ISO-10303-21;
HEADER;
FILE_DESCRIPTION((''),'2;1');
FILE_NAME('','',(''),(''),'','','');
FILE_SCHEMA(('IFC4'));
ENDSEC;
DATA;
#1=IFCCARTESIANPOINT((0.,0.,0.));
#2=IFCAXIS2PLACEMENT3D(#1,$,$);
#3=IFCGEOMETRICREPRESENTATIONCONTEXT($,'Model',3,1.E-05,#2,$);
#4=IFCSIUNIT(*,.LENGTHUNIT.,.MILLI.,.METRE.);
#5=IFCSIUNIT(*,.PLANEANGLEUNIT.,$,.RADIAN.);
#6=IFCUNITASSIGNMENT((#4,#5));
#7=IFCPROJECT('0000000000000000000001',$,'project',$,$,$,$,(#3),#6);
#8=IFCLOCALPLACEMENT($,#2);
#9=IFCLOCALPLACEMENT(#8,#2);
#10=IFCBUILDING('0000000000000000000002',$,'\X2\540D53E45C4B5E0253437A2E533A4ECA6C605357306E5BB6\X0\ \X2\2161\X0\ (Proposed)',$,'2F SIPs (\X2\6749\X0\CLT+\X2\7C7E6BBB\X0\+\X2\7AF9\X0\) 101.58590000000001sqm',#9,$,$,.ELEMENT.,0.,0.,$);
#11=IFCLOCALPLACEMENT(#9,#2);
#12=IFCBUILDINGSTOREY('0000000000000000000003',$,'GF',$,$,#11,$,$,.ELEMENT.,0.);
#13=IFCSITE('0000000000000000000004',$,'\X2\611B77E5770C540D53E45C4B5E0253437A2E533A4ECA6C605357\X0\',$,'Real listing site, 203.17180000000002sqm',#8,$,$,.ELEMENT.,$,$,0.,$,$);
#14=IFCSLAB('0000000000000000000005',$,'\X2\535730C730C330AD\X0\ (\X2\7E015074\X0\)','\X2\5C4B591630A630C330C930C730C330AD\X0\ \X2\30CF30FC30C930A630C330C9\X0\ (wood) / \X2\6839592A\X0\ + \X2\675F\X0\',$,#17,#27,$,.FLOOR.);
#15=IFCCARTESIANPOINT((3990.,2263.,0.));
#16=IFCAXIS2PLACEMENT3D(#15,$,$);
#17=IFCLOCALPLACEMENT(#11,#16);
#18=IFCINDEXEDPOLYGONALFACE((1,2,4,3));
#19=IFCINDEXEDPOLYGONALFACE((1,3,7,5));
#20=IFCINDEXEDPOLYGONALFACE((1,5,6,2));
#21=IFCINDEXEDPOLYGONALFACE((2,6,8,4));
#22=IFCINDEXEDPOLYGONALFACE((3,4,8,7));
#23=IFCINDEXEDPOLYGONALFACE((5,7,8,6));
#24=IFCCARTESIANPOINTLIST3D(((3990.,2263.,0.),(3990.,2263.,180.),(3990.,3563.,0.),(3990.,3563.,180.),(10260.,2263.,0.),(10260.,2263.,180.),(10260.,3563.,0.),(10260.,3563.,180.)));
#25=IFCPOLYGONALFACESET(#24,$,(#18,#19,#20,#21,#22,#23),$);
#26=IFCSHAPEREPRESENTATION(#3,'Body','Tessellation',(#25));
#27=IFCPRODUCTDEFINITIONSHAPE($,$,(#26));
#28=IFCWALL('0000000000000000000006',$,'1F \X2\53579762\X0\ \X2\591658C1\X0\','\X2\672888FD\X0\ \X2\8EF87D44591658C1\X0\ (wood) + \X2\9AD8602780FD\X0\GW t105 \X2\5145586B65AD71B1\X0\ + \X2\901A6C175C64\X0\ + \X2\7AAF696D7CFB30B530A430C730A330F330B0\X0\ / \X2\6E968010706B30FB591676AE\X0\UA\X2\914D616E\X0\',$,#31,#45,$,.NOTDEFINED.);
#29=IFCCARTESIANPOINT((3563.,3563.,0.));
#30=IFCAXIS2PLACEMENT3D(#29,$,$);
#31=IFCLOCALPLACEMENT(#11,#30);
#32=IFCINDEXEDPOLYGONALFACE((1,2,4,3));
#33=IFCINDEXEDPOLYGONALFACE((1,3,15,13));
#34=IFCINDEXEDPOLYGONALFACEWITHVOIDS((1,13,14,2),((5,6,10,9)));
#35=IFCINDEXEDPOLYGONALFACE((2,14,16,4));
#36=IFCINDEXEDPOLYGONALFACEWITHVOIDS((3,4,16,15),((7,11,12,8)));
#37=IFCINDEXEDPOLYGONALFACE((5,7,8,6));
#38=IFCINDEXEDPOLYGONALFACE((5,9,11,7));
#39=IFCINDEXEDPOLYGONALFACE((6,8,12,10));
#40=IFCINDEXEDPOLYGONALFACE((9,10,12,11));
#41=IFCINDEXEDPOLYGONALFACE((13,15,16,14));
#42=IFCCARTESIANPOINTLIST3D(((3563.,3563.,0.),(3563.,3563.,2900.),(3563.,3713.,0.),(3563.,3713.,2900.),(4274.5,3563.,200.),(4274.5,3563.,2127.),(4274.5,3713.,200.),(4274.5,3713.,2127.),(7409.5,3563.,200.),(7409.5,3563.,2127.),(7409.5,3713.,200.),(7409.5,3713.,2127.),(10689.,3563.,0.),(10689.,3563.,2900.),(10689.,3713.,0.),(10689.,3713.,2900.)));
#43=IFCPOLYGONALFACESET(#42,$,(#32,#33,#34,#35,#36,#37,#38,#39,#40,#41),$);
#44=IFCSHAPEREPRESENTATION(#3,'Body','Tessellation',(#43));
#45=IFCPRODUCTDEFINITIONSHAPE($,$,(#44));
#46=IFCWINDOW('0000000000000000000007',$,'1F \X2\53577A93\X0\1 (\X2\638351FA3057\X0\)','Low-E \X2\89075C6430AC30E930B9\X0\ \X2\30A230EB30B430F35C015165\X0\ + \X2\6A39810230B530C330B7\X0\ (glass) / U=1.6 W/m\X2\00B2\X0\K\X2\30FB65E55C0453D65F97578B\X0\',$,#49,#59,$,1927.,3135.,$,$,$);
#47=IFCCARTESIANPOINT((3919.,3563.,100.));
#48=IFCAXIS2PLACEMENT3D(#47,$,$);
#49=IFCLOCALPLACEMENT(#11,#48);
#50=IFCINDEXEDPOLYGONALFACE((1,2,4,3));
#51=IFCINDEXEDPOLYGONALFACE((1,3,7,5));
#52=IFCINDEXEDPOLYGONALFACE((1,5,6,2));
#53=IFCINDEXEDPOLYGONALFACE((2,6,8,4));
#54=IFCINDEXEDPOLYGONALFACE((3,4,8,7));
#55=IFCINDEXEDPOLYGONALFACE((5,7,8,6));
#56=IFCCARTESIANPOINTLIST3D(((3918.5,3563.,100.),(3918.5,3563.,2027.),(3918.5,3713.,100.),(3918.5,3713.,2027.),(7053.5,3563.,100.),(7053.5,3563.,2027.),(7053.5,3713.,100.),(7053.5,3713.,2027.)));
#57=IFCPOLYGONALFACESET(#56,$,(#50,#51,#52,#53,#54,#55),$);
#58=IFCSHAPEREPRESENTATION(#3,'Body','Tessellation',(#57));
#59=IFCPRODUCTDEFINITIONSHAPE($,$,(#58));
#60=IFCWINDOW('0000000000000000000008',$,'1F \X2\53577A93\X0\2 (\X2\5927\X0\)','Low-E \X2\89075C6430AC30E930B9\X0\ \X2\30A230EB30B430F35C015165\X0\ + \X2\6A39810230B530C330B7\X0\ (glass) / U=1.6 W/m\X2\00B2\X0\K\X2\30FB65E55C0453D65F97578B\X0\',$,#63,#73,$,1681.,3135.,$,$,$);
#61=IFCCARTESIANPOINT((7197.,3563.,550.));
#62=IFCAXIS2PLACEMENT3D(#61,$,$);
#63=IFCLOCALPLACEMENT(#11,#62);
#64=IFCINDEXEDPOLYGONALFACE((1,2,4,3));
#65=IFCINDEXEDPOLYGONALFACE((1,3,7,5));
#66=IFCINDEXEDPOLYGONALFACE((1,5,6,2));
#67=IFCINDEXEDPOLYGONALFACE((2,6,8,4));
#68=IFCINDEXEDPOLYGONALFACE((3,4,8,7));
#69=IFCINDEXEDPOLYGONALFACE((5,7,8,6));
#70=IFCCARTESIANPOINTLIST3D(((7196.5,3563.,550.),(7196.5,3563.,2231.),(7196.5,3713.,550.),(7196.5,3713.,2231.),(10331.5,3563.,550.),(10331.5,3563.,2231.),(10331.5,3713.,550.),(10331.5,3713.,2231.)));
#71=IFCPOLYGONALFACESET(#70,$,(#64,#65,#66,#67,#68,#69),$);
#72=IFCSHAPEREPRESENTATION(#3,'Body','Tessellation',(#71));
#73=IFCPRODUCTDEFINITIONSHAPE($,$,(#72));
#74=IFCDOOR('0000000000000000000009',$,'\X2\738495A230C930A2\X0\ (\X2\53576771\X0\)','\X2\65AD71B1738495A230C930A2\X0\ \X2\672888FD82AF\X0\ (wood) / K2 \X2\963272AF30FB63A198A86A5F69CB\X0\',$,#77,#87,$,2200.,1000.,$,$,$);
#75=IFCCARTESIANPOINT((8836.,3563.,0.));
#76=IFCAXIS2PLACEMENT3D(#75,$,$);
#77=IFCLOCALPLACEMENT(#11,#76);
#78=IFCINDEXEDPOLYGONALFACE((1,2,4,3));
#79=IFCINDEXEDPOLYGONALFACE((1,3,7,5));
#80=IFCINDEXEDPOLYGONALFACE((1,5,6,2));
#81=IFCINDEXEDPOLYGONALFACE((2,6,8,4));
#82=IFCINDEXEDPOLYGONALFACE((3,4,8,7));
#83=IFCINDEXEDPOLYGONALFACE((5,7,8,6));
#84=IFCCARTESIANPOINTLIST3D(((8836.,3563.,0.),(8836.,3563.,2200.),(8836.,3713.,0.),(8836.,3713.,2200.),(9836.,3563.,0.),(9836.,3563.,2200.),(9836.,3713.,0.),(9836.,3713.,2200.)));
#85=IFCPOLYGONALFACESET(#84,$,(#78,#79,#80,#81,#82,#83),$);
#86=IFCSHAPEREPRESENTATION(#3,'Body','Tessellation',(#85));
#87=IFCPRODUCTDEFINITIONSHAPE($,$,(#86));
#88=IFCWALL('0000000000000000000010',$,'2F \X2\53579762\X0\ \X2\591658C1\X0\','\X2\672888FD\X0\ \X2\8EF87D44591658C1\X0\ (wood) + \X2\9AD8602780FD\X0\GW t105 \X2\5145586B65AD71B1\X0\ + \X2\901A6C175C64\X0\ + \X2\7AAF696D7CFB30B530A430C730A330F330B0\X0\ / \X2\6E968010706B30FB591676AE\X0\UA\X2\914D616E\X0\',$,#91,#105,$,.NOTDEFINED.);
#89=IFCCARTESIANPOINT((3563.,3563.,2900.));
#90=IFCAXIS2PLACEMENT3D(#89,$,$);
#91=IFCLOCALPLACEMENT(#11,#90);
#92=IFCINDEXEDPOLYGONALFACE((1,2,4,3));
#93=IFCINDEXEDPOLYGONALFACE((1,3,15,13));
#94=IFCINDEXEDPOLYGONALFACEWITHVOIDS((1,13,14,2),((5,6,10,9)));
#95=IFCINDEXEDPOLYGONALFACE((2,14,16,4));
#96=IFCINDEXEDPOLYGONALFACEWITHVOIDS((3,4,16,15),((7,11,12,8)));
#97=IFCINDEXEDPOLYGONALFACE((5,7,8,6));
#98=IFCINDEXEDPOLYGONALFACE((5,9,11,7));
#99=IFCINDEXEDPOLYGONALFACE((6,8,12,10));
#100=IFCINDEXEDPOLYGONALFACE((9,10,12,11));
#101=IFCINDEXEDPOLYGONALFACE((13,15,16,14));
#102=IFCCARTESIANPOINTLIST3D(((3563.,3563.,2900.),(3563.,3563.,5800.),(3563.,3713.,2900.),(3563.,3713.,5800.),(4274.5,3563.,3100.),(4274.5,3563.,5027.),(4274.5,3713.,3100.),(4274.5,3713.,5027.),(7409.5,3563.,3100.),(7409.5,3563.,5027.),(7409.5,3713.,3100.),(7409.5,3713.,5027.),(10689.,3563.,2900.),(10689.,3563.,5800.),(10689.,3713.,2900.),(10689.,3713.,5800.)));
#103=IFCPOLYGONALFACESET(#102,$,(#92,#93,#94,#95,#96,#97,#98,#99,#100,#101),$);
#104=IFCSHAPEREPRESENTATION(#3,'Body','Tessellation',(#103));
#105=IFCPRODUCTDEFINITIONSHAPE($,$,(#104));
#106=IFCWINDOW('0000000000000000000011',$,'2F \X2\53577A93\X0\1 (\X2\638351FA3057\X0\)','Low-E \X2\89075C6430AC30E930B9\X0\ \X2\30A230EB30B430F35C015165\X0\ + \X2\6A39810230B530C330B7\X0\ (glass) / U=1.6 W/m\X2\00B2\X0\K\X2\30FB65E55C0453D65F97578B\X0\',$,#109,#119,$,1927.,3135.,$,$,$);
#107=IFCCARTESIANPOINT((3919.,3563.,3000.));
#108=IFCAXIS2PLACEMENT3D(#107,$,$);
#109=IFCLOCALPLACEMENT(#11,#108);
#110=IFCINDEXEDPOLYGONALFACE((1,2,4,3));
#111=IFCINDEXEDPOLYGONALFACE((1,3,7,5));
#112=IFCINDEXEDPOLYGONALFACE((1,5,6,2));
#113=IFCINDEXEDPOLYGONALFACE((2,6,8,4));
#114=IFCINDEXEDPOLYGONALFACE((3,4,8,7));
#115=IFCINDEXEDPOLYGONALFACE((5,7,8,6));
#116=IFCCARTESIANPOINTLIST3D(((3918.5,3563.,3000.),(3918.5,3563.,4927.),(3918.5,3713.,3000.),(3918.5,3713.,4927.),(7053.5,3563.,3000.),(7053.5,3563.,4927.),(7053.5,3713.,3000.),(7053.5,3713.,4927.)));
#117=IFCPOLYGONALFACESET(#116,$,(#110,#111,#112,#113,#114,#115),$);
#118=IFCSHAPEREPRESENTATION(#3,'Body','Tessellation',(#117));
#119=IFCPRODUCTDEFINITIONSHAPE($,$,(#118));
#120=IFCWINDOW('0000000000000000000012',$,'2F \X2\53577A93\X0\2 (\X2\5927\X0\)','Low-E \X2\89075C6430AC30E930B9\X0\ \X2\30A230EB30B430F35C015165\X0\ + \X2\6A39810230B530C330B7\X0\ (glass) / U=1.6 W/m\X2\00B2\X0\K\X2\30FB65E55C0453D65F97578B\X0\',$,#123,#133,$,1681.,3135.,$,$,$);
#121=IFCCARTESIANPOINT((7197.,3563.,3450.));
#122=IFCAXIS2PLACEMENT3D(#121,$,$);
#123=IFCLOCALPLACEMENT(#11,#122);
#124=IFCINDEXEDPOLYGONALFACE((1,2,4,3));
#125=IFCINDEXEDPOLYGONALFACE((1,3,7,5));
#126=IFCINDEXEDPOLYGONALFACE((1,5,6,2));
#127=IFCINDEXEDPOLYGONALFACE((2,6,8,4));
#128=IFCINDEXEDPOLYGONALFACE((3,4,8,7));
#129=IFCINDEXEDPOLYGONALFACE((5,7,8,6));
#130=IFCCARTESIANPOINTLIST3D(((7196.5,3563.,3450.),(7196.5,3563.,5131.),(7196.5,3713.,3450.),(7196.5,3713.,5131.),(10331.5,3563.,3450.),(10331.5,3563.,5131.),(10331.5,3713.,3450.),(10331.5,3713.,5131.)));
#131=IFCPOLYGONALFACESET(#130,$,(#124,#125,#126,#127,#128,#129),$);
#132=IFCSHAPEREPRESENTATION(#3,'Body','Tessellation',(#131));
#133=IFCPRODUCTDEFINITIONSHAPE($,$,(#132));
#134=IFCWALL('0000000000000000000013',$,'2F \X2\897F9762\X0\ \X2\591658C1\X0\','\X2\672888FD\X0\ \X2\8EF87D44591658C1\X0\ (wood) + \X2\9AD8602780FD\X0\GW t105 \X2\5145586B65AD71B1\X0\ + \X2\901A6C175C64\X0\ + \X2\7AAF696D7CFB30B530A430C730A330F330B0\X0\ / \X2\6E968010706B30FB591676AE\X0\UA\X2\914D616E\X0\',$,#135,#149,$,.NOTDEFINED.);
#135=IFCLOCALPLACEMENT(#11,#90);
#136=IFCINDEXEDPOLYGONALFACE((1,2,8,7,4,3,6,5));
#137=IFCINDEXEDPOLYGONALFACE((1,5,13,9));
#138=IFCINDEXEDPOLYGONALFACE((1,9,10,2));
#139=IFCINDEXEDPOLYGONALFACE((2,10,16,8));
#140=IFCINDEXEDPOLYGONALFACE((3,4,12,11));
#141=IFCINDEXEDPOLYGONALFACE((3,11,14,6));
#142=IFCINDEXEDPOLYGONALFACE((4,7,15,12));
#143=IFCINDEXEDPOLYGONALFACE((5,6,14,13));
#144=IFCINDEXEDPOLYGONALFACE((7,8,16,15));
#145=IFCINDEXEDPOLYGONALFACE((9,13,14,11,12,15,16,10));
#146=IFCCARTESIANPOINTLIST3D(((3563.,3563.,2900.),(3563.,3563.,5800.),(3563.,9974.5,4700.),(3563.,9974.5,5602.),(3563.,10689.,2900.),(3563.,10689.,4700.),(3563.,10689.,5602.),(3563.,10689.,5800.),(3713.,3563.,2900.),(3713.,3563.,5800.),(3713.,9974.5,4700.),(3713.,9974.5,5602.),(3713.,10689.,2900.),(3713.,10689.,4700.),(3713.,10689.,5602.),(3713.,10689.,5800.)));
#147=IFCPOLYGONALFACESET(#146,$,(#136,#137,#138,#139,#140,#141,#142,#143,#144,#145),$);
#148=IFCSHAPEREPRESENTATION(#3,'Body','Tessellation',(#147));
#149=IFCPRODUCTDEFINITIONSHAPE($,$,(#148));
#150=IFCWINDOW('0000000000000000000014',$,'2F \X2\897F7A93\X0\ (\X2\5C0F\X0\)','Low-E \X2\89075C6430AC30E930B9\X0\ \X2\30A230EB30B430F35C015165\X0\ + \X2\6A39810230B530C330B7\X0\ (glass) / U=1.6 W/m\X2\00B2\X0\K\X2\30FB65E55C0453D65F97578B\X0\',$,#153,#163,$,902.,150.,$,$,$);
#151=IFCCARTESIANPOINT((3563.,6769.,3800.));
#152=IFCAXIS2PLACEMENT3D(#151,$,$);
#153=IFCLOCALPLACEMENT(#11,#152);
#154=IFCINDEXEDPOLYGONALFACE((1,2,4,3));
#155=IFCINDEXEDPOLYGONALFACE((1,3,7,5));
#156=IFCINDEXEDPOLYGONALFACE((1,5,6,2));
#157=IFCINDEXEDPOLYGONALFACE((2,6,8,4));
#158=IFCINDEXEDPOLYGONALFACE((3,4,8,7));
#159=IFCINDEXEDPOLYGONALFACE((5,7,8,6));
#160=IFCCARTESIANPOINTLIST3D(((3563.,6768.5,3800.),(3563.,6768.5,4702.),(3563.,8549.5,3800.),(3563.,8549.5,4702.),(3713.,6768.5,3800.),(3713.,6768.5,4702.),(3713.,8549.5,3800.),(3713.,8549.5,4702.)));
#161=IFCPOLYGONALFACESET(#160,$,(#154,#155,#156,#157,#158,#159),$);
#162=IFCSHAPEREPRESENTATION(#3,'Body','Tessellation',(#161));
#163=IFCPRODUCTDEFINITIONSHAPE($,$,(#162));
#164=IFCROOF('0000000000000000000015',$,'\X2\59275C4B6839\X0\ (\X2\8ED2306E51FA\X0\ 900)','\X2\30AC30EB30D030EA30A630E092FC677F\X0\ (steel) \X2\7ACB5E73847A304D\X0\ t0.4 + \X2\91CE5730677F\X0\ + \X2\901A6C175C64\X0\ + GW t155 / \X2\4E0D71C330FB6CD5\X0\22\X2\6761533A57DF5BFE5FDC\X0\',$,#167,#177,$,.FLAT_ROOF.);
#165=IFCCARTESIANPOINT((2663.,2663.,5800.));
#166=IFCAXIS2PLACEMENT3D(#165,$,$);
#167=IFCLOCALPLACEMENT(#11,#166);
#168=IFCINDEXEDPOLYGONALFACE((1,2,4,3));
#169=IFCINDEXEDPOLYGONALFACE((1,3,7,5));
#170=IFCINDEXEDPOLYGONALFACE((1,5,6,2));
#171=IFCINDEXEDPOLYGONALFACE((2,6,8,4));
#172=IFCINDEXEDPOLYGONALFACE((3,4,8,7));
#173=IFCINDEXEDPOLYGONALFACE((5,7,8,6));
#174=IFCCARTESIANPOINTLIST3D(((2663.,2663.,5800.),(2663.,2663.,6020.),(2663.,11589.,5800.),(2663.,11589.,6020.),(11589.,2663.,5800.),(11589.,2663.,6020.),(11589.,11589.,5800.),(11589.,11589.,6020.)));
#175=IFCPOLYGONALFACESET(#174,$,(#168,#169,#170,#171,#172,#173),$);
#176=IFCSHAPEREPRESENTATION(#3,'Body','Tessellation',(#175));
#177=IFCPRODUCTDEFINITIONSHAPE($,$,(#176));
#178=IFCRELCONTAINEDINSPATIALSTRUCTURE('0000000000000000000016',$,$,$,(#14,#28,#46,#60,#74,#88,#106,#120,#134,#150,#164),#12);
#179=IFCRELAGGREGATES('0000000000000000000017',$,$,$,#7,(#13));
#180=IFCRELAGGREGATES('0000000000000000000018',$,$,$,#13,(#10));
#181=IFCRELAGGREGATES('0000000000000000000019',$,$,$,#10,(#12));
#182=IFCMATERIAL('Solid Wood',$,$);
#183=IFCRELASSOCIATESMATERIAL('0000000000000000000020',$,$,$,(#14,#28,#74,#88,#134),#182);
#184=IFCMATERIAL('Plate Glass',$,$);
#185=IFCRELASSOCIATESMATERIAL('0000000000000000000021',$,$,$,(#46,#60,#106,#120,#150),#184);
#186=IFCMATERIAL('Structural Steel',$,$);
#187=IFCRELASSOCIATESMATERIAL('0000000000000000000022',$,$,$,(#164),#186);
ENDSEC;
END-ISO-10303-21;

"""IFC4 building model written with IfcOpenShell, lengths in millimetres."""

from ifc_helpers import new_model, si_unit, frame, frame_2d, origin, place, context, project, spatial, rectangle, extrude, material, element, fill, save


model = new_model("IFC4")

# Units and contexts
model_context = context("Model", 3, precision=1e-05, world=origin())
ifc_project = project(units=[si_unit("LENGTHUNIT", "METRE", prefix="MILLI"), si_unit("PLANEANGLEUNIT", "RADIAN")], contexts=[model_context])

# Site, building, storey
site_placement = place(None, origin())
site = spatial("IfcSite", under=ifc_project, at=site_placement, Name="愛知県名古屋市千種区今池南", ObjectType="Real listing site, 203.17180000000002sqm", CompositionType="ELEMENT", RefElevation=0.0)
building_placement = place(site_placement, origin())
building = spatial("IfcBuilding", under=site, at=building_placement, Name="名古屋市千種区今池南の家 Ⅱ (Proposed)", ObjectType="2F SIPs (杉CLT+籾殻+竹) 101.58590000000001sqm", CompositionType="ELEMENT", ElevationOfRefHeight=0.0, ElevationOfTerrain=0.0)
storey_placement = place(building_placement, origin())
storey = spatial("IfcBuildingStorey", under=building, at=storey_placement, Name="GF", CompositionType="ELEMENT", Elevation=0.0)

# Slab
ifc_material_1 = material(Name="Solid Wood")
slab_1_placement = place(storey_placement, frame((3990.0, 2263.0, 0.0)))
element("IfcSlab", 1, at=slab_1_placement, inside=storey, material=ifc_material_1, Name="南デッキ (縁側)", Description="屋外ウッドデッキ ハードウッド (wood) / 根太 + 束", PredefinedType="FLOOR", context=model_context, shape_type="SweptSolid", body=[
    extrude(rectangle(XDim=6270.0, YDim=1300.0, at=frame_2d((3135.0, 650.0))), frame((3990.0, 2263.0, 0.0)), (0.0, 0.0, 1.0), 180.0),
])

# Wall, openings, windows, door
wall_1_placement = place(storey_placement, frame((3563.0, 3563.0, 0.0)))
wall_1 = element("IfcWall", 2, at=wall_1_placement, inside=storey, material=ifc_material_1, Name="1F 南面 外壁", Description="木製 軸組外壁 (wood) + 高性能GW t105 充填断熱 + 通気層 + 窯業系サイディング / 準耐火・外皮UA配慮", PredefinedType="NOTDEFINED", context=model_context, shape_type="SweptSolid", body=[
    extrude(rectangle(XDim=7126.0, YDim=150.0, at=frame_2d((3563.0, 75.0))), frame((3563.0, 3563.0, 0.0)), (0.0, 0.0, 1.0), 2900.0),
])
opening_1_placement = place(storey_placement, frame((3919.0, 3563.0, 100.0)))
opening_1 = element("IfcOpeningElement", 3, at=opening_1_placement, cuts=wall_1, PredefinedType="NOTDEFINED", context=model_context, shape_type="SweptSolid", body=[
    extrude(rectangle(XDim=3135.0, YDim=150.0, at=frame_2d((1567.0, 75.0))), frame((3919.0, 3563.0, 100.0)), (0.0, 0.0, 1.0), 1927.0),
])
opening_2_placement = place(storey_placement, frame((7197.0, 3563.0, 550.0)))
opening_2 = element("IfcOpeningElement", 4, at=opening_2_placement, cuts=wall_1, PredefinedType="NOTDEFINED", context=model_context, shape_type="SweptSolid", body=[
    extrude(rectangle(XDim=3135.0, YDim=150.0, at=frame_2d((1567.0, 75.0))), frame((7197.0, 3563.0, 550.0)), (0.0, 0.0, 1.0), 1681.0),
])
opening_3_placement = place(storey_placement, frame((8836.0, 3563.0, 0.0)))
opening_3 = element("IfcOpeningElement", 5, at=opening_3_placement, cuts=wall_1, PredefinedType="NOTDEFINED", context=model_context, shape_type="SweptSolid", body=[
    extrude(rectangle(XDim=1000.0, YDim=150.0, at=frame_2d((500.0, 75.0))), frame((8836.0, 3563.0, 0.0)), (0.0, 0.0, 1.0), 2200.0),
])
ifc_material_2 = material(Name="Plate Glass")
window_1_placement = place(storey_placement, frame((3919.0, 3563.0, 100.0)))
window_1 = element("IfcWindow", 6, at=window_1_placement, inside=storey, material=ifc_material_2, Name="1F 南窓1 (掃出し)", Description="Low-E 複層ガラス アルゴン封入 + 樹脂サッシ (glass) / U=1.6 W/m²K・日射取得型", OverallHeight=1927.0, OverallWidth=3135.0, context=model_context, shape_type="SweptSolid", body=[
    extrude(rectangle(XDim=3135.0, YDim=150.0, at=frame_2d((1567.0, 75.0))), frame((3919.0, 3563.0, 100.0)), (0.0, 0.0, 1.0), 1927.0),
])
fill(opening_1, window_1)
window_2_placement = place(storey_placement, frame((7197.0, 3563.0, 550.0)))
window_2 = element("IfcWindow", 7, at=window_2_placement, inside=storey, material=ifc_material_2, Name="1F 南窓2 (大)", Description="Low-E 複層ガラス アルゴン封入 + 樹脂サッシ (glass) / U=1.6 W/m²K・日射取得型", OverallHeight=1681.0, OverallWidth=3135.0, context=model_context, shape_type="SweptSolid", body=[
    extrude(rectangle(XDim=3135.0, YDim=150.0, at=frame_2d((1567.0, 75.0))), frame((7197.0, 3563.0, 550.0)), (0.0, 0.0, 1.0), 1681.0),
])
fill(opening_2, window_2)
door_placement = place(storey_placement, frame((8836.0, 3563.0, 0.0)))
door = element("IfcDoor", 8, at=door_placement, inside=storey, material=ifc_material_1, Name="玄関ドア (南東)", Description="断熱玄関ドア 木製芯 (wood) / K2 防犯・採風機構", OverallHeight=2200.0, OverallWidth=1000.0, context=model_context, shape_type="SweptSolid", body=[
    extrude(rectangle(XDim=1000.0, YDim=150.0, at=frame_2d((500.0, 75.0))), frame((8836.0, 3563.0, 0.0)), (0.0, 0.0, 1.0), 2200.0),
])
fill(opening_3, door)

# Wall, openings, windows
wall_2_placement = place(storey_placement, frame((3563.0, 3563.0, 2900.0)))
wall_2 = element("IfcWall", 9, at=wall_2_placement, inside=storey, material=ifc_material_1, Name="2F 南面 外壁", Description="木製 軸組外壁 (wood) + 高性能GW t105 充填断熱 + 通気層 + 窯業系サイディング / 準耐火・外皮UA配慮", PredefinedType="NOTDEFINED", context=model_context, shape_type="SweptSolid", body=[
    extrude(rectangle(XDim=7126.0, YDim=150.0, at=frame_2d((3563.0, 75.0))), frame((3563.0, 3563.0, 2900.0)), (0.0, 0.0, 1.0), 2900.0),
])
opening_4_placement = place(storey_placement, frame((3919.0, 3563.0, 3000.0)))
opening_4 = element("IfcOpeningElement", 10, at=opening_4_placement, cuts=wall_2, PredefinedType="NOTDEFINED", context=model_context, shape_type="SweptSolid", body=[
    extrude(rectangle(XDim=3135.0, YDim=150.0, at=frame_2d((1567.0, 75.0))), frame((3919.0, 3563.0, 3000.0)), (0.0, 0.0, 1.0), 1927.0),
])
opening_5_placement = place(storey_placement, frame((7197.0, 3563.0, 3450.0)))
opening_5 = element("IfcOpeningElement", 11, at=opening_5_placement, cuts=wall_2, PredefinedType="NOTDEFINED", context=model_context, shape_type="SweptSolid", body=[
    extrude(rectangle(XDim=3135.0, YDim=150.0, at=frame_2d((1567.0, 75.0))), frame((7197.0, 3563.0, 3450.0)), (0.0, 0.0, 1.0), 1681.0),
])
window_3_placement = place(storey_placement, frame((3919.0, 3563.0, 3000.0)))
window_3 = element("IfcWindow", 12, at=window_3_placement, inside=storey, material=ifc_material_2, Name="2F 南窓1 (掃出し)", Description="Low-E 複層ガラス アルゴン封入 + 樹脂サッシ (glass) / U=1.6 W/m²K・日射取得型", OverallHeight=1927.0, OverallWidth=3135.0, context=model_context, shape_type="SweptSolid", body=[
    extrude(rectangle(XDim=3135.0, YDim=150.0, at=frame_2d((1567.0, 75.0))), frame((3919.0, 3563.0, 3000.0)), (0.0, 0.0, 1.0), 1927.0),
])
fill(opening_4, window_3)
window_4_placement = place(storey_placement, frame((7197.0, 3563.0, 3450.0)))
window_4 = element("IfcWindow", 13, at=window_4_placement, inside=storey, material=ifc_material_2, Name="2F 南窓2 (大)", Description="Low-E 複層ガラス アルゴン封入 + 樹脂サッシ (glass) / U=1.6 W/m²K・日射取得型", OverallHeight=1681.0, OverallWidth=3135.0, context=model_context, shape_type="SweptSolid", body=[
    extrude(rectangle(XDim=3135.0, YDim=150.0, at=frame_2d((1567.0, 75.0))), frame((7197.0, 3563.0, 3450.0)), (0.0, 0.0, 1.0), 1681.0),
])
fill(opening_5, window_4)

# Wall, opening, window
wall_3_placement = place(storey_placement, frame((3563.0, 3563.0, 2900.0)))
wall_3 = element("IfcWall", 14, at=wall_3_placement, inside=storey, material=ifc_material_1, Name="2F 西面 外壁", Description="木製 軸組外壁 (wood) + 高性能GW t105 充填断熱 + 通気層 + 窯業系サイディング / 準耐火・外皮UA配慮", PredefinedType="NOTDEFINED", context=model_context, shape_type="SweptSolid", body=[
    extrude(rectangle(XDim=150.0, YDim=7126.0, at=frame_2d((75.0, 3563.0))), frame((3563.0, 3563.0, 2900.0)), (0.0, 0.0, 1.0), 2900.0),
])
opening_6_placement = place(storey_placement, frame((3563.0, 6769.0, 3800.0)))
opening_6 = element("IfcOpeningElement", 15, at=opening_6_placement, cuts=wall_3, PredefinedType="NOTDEFINED", context=model_context, shape_type="SweptSolid", body=[
    extrude(rectangle(XDim=150.0, YDim=1781.0, at=frame_2d((75.0, 890.0))), frame((3563.0, 6769.0, 3800.0)), (0.0, 0.0, 1.0), 902.0),
])
window_5_placement = place(storey_placement, frame((3563.0, 6769.0, 3800.0)))
window_5 = element("IfcWindow", 16, at=window_5_placement, inside=storey, material=ifc_material_2, Name="2F 西窓 (小)", Description="Low-E 複層ガラス アルゴン封入 + 樹脂サッシ (glass) / U=1.6 W/m²K・日射取得型", OverallHeight=902.0, OverallWidth=150.0, context=model_context, shape_type="SweptSolid", body=[
    extrude(rectangle(XDim=150.0, YDim=1781.0, at=frame_2d((75.0, 890.0))), frame((3563.0, 6769.0, 3800.0)), (0.0, 0.0, 1.0), 902.0),
])
fill(opening_6, window_5)

# Roof
ifc_material_3 = material(Name="Structural Steel")
roof_placement = place(storey_placement, frame((2663.0, 2663.0, 5800.0)))
element("IfcRoof", 17, at=roof_placement, inside=storey, material=ifc_material_3, Name="大屋根 (軒の出 900)", Description="ガルバリウム鋼板 (steel) 立平葺き t0.4 + 野地板 + 通気層 + GW t155 / 不燃・法22条区域対応", PredefinedType="FLAT_ROOF", context=model_context, shape_type="SweptSolid", body=[
    extrude(rectangle(XDim=8926.0, YDim=8926.0, at=frame_2d((4463.0, 4463.0))), frame((2663.0, 2663.0, 5800.0)), (0.0, 0.0, 1.0), 220.0),
])

save(model, "model.ifc")
